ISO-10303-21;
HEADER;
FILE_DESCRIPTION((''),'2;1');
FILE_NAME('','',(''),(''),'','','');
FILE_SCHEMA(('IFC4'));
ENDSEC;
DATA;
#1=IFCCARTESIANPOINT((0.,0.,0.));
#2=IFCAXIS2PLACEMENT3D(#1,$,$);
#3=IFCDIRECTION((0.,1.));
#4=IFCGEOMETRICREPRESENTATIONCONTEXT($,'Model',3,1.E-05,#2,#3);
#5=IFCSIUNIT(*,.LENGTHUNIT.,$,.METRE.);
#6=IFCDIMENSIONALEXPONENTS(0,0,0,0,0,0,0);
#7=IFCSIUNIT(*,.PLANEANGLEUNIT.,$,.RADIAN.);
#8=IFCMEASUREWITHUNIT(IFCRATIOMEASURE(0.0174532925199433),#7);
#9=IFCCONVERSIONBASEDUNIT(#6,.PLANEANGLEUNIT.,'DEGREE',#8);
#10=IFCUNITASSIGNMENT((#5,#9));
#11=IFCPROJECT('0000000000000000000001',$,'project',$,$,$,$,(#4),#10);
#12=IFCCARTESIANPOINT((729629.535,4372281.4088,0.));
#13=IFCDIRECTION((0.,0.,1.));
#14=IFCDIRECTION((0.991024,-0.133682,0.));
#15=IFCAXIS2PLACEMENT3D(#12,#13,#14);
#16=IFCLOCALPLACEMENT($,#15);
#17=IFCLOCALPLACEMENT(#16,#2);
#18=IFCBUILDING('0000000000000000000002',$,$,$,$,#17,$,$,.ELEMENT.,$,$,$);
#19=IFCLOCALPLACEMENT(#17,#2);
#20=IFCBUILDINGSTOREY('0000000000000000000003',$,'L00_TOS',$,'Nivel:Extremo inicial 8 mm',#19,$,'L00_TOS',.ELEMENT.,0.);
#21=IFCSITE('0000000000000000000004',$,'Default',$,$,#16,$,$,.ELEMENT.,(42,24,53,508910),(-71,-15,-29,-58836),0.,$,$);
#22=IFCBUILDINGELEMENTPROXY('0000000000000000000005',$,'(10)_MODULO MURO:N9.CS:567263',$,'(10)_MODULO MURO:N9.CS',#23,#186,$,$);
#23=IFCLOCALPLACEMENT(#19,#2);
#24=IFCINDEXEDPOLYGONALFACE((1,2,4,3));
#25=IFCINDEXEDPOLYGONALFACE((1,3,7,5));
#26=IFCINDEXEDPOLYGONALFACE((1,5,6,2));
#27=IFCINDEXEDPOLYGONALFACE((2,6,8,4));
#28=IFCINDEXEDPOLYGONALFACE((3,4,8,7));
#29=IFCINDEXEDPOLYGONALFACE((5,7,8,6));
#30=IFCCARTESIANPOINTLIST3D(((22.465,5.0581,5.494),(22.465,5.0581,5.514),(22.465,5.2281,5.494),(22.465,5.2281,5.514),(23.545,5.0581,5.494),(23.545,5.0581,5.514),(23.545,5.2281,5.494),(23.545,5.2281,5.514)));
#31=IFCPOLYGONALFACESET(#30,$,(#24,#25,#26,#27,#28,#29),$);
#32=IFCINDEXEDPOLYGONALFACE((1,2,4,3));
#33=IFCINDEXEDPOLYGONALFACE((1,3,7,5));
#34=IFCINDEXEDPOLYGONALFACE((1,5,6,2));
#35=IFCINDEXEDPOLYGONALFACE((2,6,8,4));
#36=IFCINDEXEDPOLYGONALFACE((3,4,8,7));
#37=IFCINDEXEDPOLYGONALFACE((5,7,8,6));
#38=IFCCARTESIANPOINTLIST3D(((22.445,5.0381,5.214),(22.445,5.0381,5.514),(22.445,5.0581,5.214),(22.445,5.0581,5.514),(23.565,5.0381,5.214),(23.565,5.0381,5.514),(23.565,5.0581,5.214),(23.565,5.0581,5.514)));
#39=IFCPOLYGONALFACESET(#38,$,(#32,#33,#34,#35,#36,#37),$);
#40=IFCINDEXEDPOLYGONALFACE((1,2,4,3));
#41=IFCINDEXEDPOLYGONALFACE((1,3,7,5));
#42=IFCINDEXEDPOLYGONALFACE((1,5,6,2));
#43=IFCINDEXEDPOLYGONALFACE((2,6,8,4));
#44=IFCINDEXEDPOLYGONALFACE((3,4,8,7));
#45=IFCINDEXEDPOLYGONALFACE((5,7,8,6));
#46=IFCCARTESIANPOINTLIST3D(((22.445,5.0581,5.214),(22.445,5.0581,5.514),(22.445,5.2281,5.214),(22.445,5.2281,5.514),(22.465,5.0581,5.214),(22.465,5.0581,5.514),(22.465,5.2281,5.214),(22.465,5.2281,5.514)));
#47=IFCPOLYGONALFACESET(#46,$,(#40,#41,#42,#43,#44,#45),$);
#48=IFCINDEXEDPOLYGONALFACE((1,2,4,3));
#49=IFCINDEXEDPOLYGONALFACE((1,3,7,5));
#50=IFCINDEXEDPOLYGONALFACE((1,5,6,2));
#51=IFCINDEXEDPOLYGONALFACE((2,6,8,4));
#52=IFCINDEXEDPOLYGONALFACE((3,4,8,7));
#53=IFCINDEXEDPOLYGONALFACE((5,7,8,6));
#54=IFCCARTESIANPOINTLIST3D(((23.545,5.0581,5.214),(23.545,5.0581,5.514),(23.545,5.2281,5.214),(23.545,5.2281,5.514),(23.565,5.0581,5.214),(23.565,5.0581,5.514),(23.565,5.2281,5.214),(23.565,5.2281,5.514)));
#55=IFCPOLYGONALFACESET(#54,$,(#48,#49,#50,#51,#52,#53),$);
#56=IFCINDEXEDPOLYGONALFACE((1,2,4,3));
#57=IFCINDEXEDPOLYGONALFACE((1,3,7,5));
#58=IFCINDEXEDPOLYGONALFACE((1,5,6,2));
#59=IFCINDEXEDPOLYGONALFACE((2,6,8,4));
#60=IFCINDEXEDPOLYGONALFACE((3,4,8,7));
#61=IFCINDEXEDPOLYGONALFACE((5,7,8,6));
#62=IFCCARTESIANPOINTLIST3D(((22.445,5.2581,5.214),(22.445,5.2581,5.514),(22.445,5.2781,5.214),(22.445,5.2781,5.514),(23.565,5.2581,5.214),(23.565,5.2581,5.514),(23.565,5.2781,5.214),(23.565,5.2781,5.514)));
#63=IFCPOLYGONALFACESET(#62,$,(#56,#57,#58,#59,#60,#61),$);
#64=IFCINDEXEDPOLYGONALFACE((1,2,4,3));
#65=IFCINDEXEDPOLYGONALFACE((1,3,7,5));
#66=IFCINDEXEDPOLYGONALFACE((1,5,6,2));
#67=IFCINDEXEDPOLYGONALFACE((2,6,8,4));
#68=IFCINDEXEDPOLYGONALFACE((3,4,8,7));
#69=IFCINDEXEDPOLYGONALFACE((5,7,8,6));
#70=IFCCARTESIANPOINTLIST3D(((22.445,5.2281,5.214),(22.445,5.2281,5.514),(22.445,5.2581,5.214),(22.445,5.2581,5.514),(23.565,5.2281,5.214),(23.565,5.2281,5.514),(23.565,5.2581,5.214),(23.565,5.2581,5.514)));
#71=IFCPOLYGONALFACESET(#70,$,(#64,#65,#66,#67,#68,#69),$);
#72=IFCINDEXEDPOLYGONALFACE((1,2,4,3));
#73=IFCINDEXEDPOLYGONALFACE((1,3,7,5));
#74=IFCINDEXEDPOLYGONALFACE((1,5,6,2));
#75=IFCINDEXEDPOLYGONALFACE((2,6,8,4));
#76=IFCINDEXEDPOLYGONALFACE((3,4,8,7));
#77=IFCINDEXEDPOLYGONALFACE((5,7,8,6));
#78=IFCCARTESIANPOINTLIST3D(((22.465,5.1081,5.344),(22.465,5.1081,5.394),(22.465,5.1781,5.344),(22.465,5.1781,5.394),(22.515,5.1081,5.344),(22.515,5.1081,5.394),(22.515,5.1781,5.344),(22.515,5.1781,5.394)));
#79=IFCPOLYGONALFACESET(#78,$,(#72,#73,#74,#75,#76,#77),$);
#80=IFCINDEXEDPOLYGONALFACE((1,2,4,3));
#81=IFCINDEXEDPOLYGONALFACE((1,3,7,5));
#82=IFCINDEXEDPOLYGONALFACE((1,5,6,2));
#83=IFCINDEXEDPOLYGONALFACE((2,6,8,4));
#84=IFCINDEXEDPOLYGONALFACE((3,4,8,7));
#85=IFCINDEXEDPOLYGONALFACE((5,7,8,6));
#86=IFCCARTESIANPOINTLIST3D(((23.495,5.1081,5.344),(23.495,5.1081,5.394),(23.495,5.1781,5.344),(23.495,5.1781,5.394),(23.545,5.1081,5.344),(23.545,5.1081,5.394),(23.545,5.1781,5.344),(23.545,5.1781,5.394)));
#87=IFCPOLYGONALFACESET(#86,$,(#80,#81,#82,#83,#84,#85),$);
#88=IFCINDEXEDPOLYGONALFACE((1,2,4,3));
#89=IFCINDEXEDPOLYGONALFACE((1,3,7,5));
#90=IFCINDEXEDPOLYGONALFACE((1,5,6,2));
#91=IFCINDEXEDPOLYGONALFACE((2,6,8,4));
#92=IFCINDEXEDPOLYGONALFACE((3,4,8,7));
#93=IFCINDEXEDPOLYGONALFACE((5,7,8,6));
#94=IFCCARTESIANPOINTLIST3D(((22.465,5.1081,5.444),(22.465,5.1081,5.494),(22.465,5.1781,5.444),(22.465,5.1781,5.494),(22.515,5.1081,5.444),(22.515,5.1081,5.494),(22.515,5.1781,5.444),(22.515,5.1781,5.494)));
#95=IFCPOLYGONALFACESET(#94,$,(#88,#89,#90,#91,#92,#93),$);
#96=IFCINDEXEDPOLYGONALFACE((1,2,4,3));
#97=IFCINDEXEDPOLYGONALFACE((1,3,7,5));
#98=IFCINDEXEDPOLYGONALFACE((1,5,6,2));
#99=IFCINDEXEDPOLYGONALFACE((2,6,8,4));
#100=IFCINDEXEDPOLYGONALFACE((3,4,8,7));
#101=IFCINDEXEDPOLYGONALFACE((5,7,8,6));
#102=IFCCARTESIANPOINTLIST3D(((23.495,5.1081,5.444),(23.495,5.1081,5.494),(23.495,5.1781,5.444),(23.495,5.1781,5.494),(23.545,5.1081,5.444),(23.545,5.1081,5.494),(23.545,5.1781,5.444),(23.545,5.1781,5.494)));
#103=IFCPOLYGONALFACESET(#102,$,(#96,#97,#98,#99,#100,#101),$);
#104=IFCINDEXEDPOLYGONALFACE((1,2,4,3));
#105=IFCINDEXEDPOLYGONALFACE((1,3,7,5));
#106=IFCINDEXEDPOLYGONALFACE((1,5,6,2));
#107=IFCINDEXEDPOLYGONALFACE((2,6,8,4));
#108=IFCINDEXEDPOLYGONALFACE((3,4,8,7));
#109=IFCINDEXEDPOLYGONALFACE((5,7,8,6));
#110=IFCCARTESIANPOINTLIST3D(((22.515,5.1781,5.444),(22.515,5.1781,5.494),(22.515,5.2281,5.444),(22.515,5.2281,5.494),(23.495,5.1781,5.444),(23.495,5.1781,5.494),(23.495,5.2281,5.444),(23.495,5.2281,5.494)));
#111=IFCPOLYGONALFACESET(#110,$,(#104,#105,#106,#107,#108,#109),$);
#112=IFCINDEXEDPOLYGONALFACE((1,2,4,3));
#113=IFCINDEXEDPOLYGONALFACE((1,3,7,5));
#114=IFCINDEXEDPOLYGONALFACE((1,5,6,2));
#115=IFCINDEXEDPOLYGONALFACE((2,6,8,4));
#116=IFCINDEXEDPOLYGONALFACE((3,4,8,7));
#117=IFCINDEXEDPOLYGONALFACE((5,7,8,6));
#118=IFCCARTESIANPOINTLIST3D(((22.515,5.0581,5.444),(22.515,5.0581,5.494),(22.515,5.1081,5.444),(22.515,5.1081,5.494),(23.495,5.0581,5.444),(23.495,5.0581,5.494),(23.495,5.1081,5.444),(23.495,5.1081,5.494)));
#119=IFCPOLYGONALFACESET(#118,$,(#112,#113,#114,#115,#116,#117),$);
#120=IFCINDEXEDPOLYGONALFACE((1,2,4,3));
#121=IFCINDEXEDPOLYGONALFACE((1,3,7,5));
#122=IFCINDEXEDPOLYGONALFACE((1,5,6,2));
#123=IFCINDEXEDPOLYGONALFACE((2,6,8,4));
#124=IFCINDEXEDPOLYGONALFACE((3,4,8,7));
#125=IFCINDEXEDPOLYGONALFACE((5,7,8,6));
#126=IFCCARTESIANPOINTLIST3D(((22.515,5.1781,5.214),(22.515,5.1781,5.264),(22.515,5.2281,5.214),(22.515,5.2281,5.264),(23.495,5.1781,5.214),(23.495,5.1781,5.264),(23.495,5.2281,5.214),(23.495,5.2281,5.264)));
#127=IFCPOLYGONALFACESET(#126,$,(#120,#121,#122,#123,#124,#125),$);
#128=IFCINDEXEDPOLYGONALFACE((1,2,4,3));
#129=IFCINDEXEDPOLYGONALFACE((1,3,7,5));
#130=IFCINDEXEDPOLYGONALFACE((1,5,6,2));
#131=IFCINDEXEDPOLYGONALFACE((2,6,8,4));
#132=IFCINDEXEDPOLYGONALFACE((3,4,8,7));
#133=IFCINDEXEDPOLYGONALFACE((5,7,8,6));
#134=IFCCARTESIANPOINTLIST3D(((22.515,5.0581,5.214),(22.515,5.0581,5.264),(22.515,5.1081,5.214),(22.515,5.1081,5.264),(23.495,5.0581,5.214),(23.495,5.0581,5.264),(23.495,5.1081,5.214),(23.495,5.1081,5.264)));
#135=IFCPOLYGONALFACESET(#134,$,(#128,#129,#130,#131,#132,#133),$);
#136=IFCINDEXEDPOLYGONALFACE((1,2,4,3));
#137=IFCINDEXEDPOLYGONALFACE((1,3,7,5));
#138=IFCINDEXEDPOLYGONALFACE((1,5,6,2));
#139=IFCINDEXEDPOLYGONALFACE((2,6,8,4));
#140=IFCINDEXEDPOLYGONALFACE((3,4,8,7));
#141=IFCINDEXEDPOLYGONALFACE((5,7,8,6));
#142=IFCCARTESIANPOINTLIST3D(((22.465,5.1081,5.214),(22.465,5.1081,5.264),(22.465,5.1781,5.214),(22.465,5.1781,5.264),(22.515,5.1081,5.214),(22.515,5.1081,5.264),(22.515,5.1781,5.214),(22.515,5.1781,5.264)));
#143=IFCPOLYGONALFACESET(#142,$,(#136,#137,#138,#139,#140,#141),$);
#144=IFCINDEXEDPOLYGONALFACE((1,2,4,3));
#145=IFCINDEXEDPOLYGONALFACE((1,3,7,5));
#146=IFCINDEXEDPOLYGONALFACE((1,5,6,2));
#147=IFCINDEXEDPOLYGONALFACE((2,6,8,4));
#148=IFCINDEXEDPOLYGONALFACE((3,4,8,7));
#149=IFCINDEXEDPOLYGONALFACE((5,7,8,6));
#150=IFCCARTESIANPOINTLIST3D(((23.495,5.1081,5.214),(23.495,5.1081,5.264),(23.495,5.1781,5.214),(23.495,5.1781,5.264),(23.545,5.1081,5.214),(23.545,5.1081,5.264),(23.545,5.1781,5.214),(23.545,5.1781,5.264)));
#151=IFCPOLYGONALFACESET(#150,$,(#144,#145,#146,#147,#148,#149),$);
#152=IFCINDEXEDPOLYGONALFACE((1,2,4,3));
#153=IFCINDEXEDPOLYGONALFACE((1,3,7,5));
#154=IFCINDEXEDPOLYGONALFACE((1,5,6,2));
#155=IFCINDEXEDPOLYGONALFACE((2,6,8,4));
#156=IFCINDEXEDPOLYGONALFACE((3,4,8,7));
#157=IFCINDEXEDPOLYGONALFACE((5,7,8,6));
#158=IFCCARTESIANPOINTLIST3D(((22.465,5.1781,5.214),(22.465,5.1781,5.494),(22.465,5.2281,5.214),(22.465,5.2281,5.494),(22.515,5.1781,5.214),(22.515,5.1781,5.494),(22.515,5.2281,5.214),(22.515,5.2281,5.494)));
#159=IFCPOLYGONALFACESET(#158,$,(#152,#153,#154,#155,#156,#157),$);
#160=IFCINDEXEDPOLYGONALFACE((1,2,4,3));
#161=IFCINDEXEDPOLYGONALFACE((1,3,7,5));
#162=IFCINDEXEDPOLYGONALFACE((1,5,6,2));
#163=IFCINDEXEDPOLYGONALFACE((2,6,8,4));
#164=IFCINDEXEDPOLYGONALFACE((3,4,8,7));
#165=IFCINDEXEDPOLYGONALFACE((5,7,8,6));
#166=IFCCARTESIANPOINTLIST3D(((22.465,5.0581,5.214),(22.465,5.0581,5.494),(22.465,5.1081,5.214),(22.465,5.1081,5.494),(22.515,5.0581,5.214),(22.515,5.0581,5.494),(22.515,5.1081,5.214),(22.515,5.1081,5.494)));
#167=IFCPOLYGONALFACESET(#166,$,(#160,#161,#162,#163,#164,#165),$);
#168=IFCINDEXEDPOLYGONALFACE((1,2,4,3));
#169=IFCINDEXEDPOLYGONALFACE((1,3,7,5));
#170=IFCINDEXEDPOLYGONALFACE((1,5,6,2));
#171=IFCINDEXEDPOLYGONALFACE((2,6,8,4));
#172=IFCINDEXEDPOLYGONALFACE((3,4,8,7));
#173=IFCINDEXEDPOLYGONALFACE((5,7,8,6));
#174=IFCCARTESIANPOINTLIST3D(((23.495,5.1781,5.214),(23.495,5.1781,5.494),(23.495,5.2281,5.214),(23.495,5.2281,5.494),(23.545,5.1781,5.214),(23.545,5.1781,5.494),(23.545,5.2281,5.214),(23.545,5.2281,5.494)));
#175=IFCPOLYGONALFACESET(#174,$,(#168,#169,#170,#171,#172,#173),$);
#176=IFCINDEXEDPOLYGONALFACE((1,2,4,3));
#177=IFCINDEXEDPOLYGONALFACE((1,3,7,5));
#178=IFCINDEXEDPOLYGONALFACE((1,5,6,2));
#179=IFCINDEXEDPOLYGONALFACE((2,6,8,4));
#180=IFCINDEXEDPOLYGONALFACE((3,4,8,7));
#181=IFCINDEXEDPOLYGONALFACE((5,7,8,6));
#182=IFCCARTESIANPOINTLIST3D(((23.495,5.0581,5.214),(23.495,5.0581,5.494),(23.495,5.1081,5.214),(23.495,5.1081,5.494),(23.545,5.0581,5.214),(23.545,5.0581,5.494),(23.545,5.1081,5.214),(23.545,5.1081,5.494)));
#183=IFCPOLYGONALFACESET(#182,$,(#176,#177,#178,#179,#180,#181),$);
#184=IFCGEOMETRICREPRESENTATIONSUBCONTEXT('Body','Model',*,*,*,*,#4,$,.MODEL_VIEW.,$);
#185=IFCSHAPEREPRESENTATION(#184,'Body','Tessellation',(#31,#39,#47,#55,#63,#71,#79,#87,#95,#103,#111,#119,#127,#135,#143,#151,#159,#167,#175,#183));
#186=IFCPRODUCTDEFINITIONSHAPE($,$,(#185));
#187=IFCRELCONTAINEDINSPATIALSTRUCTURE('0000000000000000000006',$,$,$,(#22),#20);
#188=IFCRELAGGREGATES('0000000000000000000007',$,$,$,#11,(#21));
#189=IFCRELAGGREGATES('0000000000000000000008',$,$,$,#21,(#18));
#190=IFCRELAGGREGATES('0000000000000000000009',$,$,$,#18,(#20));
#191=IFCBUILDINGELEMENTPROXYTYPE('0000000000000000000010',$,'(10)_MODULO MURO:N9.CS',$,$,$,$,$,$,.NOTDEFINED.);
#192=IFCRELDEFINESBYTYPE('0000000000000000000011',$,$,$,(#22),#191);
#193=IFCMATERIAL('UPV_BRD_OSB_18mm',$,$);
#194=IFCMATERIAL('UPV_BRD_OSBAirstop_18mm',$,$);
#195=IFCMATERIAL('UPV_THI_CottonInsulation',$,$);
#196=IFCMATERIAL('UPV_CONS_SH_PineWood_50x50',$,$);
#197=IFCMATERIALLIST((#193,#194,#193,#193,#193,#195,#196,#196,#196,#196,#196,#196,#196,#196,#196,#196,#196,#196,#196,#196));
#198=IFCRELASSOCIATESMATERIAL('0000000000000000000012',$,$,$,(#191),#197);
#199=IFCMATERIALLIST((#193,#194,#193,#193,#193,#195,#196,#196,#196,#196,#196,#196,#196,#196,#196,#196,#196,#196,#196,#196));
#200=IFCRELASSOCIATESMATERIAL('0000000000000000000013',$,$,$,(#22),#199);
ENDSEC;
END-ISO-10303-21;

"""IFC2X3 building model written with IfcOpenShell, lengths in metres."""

from ifc_helpers import new_model, entity, si_unit, converted_unit, direction, frame, frame_2d, origin, origin_2d_with_axis, place, context, subcontext, project, spatial, rectangle, extrude, source, transform, mapped, material, material_list, type_object, type_shapes, element, save


model = new_model("IFC2X3")

# Units and contexts
model_context = context("Model", 3, precision=1e-05, world=origin(), true_north=direction((0.0, 1.0)))
body_context = subcontext(model_context, "Body", "Model", "MODEL_VIEW")
ifc_project = project(units=[si_unit("LENGTHUNIT", "METRE"), converted_unit("PLANEANGLEUNIT", "DEGREE", entity("IfcRatioMeasure", 0.0174532925199433), si_unit("PLANEANGLEUNIT", "RADIAN"), dimensions=[0, 0, 0, 0, 0, 0, 0])], contexts=[model_context])

# Site, building, storey
site_placement = place(None, frame((729629.535, 4372281.4088, 0.0), z_axis=(0.0, 0.0, 1.0), x_axis=(0.991024, -0.133682, 0.0)))
site = spatial("IfcSite", under=ifc_project, at=site_placement, Name="Default", CompositionType="ELEMENT", RefLatitude=(42, 24, 53, 508910), RefLongitude=(-71, -15, -29, -58836), RefElevation=0.0)
building_placement = place(site_placement, origin())
building = spatial("IfcBuilding", under=site, at=building_placement, CompositionType="ELEMENT")
storey_placement = place(building_placement, origin())
storey = spatial("IfcBuildingStorey", under=building, at=storey_placement, Name="L00_TOS", ObjectType="Nivel:Extremo inicial 8 mm", LongName="L00_TOS", CompositionType="ELEMENT", Elevation=0.0)

# Building element proxy
ifc_material_1 = material(Name="UPV_BRD_OSBAirstop_18mm")
ifc_material_2 = material(Name="UPV_BRD_OSB_18mm")
ifc_material_3 = material(Name="UPV_THI_CottonInsulation")
ifc_material_4 = material(Name="UPV_CONS_SH_PineWood_50x50")
ifc_material_list_1 = material_list([ifc_material_2, ifc_material_1, ifc_material_2, ifc_material_2, ifc_material_2, ifc_material_3, ifc_material_4, ifc_material_4, ifc_material_4, ifc_material_4, ifc_material_4, ifc_material_4, ifc_material_4, ifc_material_4, ifc_material_4, ifc_material_4, ifc_material_4, ifc_material_4, ifc_material_4, ifc_material_4])
ifc_material_list_2 = material_list([ifc_material_2, ifc_material_1, ifc_material_2, ifc_material_2, ifc_material_2, ifc_material_3, ifc_material_4, ifc_material_4, ifc_material_4, ifc_material_4, ifc_material_4, ifc_material_4, ifc_material_4, ifc_material_4, ifc_material_4, ifc_material_4, ifc_material_4, ifc_material_4, ifc_material_4, ifc_material_4])
building_element_proxy_type_1 = type_object("IfcBuildingElementProxyType", Name="(10)_MODULO MURO:N9.CS", PredefinedType="NOTDEFINED", material=ifc_material_list_2)
shared_shape_1 = source(origin(), body_context, "Body", "SweptSolid", [
    extrude(rectangle(XDim=1.08, YDim=0.17, at=origin_2d_with_axis()), frame((0.0, 0.0, 0.28), z_axis=(0.0, 0.0, 1.0), x_axis=(-1.0, 0.0, 0.0)), (0.0, 0.0, 1.0), 0.02),
    extrude(rectangle(XDim=1.12, YDim=0.02, at=origin_2d_with_axis()), frame((0.0, -0.095, 0.0)), (0.0, 0.0, 1.0), 0.3),
    extrude(rectangle(XDim=0.17, YDim=0.02, at=frame_2d((0.0, 0.0), x_axis=(1.0, 0.0))), frame((-0.55, 0.0, 0.0), z_axis=(0.0, 0.0, 1.0), x_axis=(0.0, -1.0, 0.0)), (0.0, 0.0, 1.0), 0.3),
    extrude(rectangle(XDim=0.17, YDim=0.02, at=frame_2d((0.0, 0.0), x_axis=(1.0, 0.0))), frame((0.55, 0.0, 0.0), z_axis=(0.0, 0.0, 1.0), x_axis=(0.0, -1.0, 0.0)), (0.0, 0.0, 1.0), 0.3),
    extrude(rectangle(XDim=1.12, YDim=0.02, at=origin_2d_with_axis()), frame((0.0, 0.125, 0.0), z_axis=(0.0, 0.0, 1.0), x_axis=(-1.0, 0.0, 0.0)), (0.0, 0.0, 1.0), 0.3),
    extrude(rectangle(XDim=1.12, YDim=0.03, at=frame_2d((0.0, 0.0), x_axis=(1.0, 0.0))), frame((0.0, 0.1, 0.0), z_axis=(0.0, 0.0, 1.0), x_axis=(-1.0, 0.0, 0.0)), (0.0, 0.0, 1.0), 0.3),
    extrude(rectangle(XDim=0.07, YDim=0.05, at=frame_2d((0.0, 0.0), x_axis=(1.0, 0.0))), frame((-0.515, 0.0, 0.13), z_axis=(0.0, 0.0, 1.0), x_axis=(0.0, 1.0, 0.0)), (0.0, 0.0, 1.0), 0.05),
    extrude(rectangle(XDim=0.07, YDim=0.05, at=origin_2d_with_axis()), frame((0.515, 0.0, 0.13), z_axis=(0.0, 0.0, 1.0), x_axis=(0.0, 1.0, 0.0)), (0.0, 0.0, 1.0), 0.05),
    extrude(rectangle(XDim=0.07, YDim=0.05, at=frame_2d((0.0, 0.0), x_axis=(1.0, 0.0))), frame((-0.515, 0.0, 0.23), z_axis=(0.0, 0.0, 1.0), x_axis=(0.0, -1.0, 0.0)), (0.0, 0.0, 1.0), 0.05),
    extrude(rectangle(XDim=0.07, YDim=0.05, at=origin_2d_with_axis()), frame((0.515, 0.0, 0.23), z_axis=(0.0, 0.0, 1.0), x_axis=(0.0, -1.0, 0.0)), (0.0, 0.0, 1.0), 0.05),
    extrude(rectangle(XDim=0.98, YDim=0.05, at=origin_2d_with_axis()), frame((0.0, 0.06, 0.23), z_axis=(0.0, 0.0, 1.0), x_axis=(-1.0, 0.0, 0.0)), (0.0, 0.0, 1.0), 0.05),
    extrude(rectangle(XDim=0.05, YDim=0.98, at=frame_2d((0.0, 0.0), x_axis=(1.0, 0.0))), frame((0.0, -0.06, 0.23), z_axis=(0.0, 0.0, 1.0), x_axis=(0.0, -1.0, 0.0)), (0.0, 0.0, 1.0), 0.05),
    extrude(rectangle(XDim=0.05, YDim=0.98, at=origin_2d_with_axis()), frame((0.0, 0.06, 0.0), z_axis=(0.0, 0.0, 1.0), x_axis=(0.0, -1.0, 0.0)), (0.0, 0.0, 1.0), 0.05),
    extrude(rectangle(XDim=0.05, YDim=0.98, at=frame_2d((0.0, 0.0), x_axis=(1.0, 0.0))), frame((0.0, -0.06, 0.0), z_axis=(0.0, 0.0, 1.0), x_axis=(0.0, -1.0, 0.0)), (0.0, 0.0, 1.0), 0.05),
    extrude(rectangle(XDim=0.07, YDim=0.05, at=frame_2d((0.0, 0.0), x_axis=(1.0, 0.0))), frame((-0.515, 0.0, 0.0), z_axis=(0.0, 0.0, 1.0), x_axis=(0.0, -1.0, 0.0)), (0.0, 0.0, 1.0), 0.05),
    extrude(rectangle(XDim=0.05, YDim=0.07, at=origin_2d_with_axis()), frame((0.515, 0.0, 0.0), z_axis=(0.0, 0.0, 1.0), x_axis=(-1.0, 0.0, 0.0)), (0.0, 0.0, 1.0), 0.05),
    extrude(rectangle(XDim=0.05, YDim=0.05, at=frame_2d((0.0, 0.0), x_axis=(1.0, 0.0))), frame((-0.515, 0.06, 0.0), z_axis=(0.0, 0.0, 1.0), x_axis=(0.0, -1.0, 0.0)), (0.0, 0.0, 1.0), 0.28),
    extrude(rectangle(XDim=0.05, YDim=0.05, at=frame_2d((0.0, 0.0), x_axis=(1.0, 0.0))), frame((-0.515, -0.06, 0.0), z_axis=(0.0, 0.0, 1.0), x_axis=(0.0, -1.0, 0.0)), (0.0, 0.0, 1.0), 0.28),
    extrude(rectangle(XDim=0.05, YDim=0.05, at=origin_2d_with_axis()), frame((0.515, 0.06, 0.0), z_axis=(0.0, 0.0, 1.0), x_axis=(0.0, -1.0, 0.0)), (0.0, 0.0, 1.0), 0.28),
    extrude(rectangle(XDim=0.05, YDim=0.05, at=frame_2d((0.0, 0.0), x_axis=(1.0, 0.0))), frame((0.515, -0.06, 0.0), z_axis=(0.0, 0.0, 1.0), x_axis=(0.0, -1.0, 0.0)), (0.0, 0.0, 1.0), 0.28),
])
type_shapes(building_element_proxy_type_1, [shared_shape_1])
proxy_1_placement = place(storey_placement, frame((23.005, 5.1431, 5.214)))
element("IfcBuildingElementProxy", 1, at=proxy_1_placement, inside=storey, type_object=building_element_proxy_type_1, material=ifc_material_list_1, Name="(10)_MODULO MURO:N9.CS:567263", ObjectType="(10)_MODULO MURO:N9.CS", context=body_context, shape_type="MappedRepresentation", body=[
    mapped(shared_shape_1, transform((0.0, 0.0, 0.0), scale=1.0)),
])

save(model, "model.ifc")
